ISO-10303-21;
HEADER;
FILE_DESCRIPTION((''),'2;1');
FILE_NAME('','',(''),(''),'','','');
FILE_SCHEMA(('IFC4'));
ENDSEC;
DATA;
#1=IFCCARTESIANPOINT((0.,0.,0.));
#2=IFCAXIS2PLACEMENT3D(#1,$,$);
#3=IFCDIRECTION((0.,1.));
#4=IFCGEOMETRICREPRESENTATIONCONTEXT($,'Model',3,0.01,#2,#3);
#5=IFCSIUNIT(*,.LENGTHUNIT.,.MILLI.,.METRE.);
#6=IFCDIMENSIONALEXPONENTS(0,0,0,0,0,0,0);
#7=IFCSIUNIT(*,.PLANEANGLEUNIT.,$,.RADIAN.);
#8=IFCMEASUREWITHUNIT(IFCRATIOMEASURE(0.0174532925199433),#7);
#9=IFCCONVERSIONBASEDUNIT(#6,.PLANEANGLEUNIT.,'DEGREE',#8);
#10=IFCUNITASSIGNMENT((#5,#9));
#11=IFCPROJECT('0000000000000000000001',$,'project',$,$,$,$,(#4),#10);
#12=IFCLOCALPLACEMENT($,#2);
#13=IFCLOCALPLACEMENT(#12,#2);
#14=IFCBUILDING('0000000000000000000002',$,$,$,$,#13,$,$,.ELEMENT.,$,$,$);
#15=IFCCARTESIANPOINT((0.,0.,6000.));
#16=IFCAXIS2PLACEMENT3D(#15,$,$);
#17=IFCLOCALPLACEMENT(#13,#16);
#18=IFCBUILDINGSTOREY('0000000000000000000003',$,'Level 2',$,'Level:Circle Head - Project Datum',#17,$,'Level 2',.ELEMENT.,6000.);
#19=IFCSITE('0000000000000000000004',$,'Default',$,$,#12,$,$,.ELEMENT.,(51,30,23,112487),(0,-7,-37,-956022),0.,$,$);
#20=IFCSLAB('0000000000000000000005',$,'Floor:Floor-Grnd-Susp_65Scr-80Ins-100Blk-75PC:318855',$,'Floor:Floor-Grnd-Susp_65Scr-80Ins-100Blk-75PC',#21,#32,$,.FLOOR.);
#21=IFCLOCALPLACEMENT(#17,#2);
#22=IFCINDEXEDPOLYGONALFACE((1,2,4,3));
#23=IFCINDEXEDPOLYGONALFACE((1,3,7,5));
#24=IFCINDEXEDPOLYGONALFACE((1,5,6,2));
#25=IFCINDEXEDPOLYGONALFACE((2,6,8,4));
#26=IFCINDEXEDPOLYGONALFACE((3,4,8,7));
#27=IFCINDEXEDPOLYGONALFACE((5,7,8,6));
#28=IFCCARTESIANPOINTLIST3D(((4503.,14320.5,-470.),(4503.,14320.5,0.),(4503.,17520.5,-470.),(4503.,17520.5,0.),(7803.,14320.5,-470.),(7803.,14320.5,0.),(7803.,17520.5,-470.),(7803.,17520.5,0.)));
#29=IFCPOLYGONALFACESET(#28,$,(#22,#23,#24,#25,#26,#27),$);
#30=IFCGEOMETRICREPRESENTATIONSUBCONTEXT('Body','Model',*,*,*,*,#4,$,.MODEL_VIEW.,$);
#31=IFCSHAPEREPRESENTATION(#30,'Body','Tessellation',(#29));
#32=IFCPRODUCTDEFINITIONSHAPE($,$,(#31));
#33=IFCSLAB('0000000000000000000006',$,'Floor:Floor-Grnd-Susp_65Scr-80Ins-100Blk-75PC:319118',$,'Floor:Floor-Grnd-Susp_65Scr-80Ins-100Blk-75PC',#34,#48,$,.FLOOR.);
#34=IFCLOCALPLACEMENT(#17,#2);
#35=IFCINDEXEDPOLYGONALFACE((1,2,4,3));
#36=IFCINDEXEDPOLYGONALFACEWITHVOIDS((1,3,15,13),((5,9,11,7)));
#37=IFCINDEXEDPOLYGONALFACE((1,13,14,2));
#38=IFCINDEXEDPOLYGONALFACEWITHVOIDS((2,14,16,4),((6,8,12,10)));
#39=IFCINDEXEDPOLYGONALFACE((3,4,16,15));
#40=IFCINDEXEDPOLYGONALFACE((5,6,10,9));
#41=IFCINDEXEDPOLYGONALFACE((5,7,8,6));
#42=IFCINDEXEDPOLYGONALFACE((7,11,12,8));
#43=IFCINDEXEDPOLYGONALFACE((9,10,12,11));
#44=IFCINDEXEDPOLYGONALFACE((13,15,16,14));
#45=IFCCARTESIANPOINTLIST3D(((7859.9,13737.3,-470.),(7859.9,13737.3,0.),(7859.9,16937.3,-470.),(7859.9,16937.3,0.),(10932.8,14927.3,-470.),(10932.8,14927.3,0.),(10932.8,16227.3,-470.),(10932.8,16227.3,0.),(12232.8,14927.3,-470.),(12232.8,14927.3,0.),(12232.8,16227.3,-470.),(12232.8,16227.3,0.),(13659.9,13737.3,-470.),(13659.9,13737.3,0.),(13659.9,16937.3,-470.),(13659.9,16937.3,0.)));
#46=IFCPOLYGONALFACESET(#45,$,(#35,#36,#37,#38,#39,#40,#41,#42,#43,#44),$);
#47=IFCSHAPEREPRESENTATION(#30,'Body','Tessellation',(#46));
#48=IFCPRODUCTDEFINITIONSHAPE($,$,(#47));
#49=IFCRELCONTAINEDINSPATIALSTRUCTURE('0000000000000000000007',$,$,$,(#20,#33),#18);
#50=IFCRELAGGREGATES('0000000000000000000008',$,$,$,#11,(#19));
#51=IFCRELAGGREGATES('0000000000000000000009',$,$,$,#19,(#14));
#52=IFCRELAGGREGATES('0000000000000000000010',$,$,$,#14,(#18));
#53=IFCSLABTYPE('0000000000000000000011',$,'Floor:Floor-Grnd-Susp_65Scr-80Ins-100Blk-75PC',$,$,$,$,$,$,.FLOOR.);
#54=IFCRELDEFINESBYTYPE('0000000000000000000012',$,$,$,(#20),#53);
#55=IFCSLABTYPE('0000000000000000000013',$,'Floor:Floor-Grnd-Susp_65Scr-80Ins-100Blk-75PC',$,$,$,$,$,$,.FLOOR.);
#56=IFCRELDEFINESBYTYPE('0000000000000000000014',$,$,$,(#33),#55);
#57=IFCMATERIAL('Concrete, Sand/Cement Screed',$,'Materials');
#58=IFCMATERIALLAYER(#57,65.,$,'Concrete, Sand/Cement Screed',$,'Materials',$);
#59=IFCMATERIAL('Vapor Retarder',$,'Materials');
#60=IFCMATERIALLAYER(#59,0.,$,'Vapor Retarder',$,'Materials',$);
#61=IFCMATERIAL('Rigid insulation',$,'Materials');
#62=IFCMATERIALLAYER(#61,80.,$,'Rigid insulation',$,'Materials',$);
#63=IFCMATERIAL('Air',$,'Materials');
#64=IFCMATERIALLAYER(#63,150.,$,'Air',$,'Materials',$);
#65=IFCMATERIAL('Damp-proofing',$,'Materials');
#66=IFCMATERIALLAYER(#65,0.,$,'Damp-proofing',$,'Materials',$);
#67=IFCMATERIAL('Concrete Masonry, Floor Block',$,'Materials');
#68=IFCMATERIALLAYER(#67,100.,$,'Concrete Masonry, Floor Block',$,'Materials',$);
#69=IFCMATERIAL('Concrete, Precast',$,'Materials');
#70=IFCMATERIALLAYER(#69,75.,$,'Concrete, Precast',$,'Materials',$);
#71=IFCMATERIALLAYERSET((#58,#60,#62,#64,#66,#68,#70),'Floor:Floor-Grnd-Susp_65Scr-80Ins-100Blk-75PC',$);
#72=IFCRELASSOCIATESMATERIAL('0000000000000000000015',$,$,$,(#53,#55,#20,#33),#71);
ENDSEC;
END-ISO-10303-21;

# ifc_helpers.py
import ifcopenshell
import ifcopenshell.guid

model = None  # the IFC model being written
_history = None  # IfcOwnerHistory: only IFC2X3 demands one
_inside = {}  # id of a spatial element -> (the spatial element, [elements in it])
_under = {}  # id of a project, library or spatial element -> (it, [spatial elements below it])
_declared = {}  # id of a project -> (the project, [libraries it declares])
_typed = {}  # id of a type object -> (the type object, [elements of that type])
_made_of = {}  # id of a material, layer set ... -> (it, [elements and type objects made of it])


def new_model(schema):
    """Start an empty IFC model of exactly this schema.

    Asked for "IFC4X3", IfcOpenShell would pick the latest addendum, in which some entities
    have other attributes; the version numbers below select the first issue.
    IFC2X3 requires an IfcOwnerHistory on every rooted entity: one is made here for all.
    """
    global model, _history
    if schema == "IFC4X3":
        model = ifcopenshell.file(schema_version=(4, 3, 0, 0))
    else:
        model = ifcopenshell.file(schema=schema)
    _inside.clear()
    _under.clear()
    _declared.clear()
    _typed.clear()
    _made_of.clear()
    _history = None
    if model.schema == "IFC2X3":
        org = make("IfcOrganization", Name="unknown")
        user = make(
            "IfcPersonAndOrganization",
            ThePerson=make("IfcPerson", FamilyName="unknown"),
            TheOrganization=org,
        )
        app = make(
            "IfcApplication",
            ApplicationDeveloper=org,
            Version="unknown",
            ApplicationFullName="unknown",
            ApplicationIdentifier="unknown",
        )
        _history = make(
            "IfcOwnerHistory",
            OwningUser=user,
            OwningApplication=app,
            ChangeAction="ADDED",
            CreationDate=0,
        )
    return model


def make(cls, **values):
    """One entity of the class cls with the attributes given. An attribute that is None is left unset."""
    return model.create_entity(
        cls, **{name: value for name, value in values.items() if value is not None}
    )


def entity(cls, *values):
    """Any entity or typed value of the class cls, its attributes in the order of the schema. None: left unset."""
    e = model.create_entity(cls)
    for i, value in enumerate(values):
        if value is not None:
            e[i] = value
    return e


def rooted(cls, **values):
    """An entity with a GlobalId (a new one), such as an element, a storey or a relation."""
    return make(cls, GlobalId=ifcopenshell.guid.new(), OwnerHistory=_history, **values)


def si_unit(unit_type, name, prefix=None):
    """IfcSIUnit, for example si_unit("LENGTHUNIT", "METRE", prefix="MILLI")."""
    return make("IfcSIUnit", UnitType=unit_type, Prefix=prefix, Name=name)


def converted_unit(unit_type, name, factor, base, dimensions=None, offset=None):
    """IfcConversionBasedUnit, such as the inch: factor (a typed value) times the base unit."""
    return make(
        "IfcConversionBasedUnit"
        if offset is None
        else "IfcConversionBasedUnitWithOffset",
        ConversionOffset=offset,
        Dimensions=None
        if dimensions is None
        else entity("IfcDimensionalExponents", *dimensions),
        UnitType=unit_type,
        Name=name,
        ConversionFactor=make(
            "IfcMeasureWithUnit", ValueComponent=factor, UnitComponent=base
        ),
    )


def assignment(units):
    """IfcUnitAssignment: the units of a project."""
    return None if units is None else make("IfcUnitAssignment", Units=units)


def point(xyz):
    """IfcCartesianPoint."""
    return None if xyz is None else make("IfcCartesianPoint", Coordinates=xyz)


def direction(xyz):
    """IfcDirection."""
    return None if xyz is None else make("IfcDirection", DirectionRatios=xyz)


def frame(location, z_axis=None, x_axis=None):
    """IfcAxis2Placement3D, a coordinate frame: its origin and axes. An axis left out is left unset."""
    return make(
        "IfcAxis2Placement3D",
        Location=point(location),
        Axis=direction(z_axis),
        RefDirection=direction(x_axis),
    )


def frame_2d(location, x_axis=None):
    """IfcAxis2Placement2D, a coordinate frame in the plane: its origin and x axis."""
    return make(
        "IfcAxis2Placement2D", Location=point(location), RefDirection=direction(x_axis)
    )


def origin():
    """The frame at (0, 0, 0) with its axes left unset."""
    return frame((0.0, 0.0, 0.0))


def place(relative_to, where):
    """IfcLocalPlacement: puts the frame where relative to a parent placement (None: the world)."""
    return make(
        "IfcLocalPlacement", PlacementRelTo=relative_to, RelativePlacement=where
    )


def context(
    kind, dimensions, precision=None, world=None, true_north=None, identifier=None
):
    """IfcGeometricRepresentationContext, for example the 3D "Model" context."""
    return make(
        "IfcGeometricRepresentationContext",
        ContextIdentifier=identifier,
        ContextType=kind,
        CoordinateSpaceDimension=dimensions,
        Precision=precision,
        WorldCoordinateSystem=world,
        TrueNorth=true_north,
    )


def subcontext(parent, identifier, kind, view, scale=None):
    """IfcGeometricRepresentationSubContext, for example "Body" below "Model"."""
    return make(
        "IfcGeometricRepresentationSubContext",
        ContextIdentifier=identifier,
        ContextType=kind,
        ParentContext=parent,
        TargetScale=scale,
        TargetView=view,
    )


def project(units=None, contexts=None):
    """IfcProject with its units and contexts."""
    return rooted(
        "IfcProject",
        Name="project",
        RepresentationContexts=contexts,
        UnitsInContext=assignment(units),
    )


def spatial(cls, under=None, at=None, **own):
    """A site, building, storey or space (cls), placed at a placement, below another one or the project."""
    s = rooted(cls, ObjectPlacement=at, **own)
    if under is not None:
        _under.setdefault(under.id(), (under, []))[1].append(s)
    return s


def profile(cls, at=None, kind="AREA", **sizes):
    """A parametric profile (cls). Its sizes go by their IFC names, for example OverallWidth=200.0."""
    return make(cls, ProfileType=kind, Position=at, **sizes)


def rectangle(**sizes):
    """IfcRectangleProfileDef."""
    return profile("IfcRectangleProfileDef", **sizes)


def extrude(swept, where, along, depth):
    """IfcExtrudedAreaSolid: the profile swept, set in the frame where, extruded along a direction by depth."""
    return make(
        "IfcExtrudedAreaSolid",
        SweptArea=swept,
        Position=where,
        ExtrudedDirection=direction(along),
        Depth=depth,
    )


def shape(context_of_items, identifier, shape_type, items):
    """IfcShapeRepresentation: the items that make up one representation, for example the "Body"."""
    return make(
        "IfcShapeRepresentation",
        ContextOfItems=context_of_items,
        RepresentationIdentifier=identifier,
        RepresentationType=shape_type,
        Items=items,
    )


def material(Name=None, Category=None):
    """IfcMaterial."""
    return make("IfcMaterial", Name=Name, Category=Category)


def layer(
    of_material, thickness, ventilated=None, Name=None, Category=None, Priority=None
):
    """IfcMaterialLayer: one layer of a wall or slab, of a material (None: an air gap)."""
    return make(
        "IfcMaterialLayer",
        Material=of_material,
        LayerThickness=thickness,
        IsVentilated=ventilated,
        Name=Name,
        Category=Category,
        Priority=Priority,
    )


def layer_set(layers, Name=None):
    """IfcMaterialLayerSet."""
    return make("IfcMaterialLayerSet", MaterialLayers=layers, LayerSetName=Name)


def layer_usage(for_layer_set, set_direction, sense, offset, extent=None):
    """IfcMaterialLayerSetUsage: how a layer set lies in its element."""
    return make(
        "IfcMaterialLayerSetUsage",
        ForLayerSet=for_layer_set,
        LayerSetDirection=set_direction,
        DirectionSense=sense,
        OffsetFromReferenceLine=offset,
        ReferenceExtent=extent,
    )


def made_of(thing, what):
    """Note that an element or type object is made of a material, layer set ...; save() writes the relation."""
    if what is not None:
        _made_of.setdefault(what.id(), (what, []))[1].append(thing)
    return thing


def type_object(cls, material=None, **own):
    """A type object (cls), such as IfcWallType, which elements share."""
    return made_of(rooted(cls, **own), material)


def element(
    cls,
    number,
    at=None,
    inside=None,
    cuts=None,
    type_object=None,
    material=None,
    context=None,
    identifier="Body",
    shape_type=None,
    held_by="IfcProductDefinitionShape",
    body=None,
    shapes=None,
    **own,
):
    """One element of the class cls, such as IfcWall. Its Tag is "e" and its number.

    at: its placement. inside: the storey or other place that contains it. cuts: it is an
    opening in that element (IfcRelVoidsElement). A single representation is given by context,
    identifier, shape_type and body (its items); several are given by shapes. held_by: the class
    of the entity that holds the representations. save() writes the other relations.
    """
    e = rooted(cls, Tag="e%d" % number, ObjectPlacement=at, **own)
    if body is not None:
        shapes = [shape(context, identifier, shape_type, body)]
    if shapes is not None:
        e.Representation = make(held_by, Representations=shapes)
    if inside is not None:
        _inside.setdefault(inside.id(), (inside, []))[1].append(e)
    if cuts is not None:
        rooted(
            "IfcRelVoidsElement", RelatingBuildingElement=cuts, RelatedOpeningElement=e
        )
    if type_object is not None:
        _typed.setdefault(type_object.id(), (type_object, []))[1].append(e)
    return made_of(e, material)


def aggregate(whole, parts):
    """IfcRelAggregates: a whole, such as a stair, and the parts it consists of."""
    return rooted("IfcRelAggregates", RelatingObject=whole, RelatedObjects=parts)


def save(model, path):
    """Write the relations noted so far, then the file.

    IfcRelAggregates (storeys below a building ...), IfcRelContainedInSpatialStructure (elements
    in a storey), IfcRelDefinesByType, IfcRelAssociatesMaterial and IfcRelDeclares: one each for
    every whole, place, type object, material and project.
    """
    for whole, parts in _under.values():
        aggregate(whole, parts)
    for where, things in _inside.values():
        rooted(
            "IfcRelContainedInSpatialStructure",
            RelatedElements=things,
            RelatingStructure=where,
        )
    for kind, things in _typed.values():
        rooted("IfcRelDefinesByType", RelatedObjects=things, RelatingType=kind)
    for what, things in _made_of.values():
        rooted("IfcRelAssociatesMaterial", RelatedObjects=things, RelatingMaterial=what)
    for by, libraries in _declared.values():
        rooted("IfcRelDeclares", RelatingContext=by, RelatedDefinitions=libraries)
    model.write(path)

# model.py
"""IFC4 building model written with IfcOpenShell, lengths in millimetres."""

from ifc_helpers import new_model, entity, si_unit, converted_unit, direction, frame, frame_2d, origin, place, context, subcontext, project, spatial, rectangle, extrude, material, layer, layer_set, layer_usage, type_object, element, save


model = new_model("IFC4")

# Units and contexts
model_context = context("Model", 3, precision=0.01, world=origin(), true_north=direction((0.0, 1.0)))
body_context = subcontext(model_context, "Body", "Model", "MODEL_VIEW")
ifc_project = project(units=[si_unit("LENGTHUNIT", "METRE", prefix="MILLI"), converted_unit("PLANEANGLEUNIT", "DEGREE", entity("IfcRatioMeasure", 0.0174532925199433), si_unit("PLANEANGLEUNIT", "RADIAN"), dimensions=[0, 0, 0, 0, 0, 0, 0])], contexts=[model_context])

# Site, building, storey
site_placement = place(None, origin())
site = spatial("IfcSite", under=ifc_project, at=site_placement, Name="Default", CompositionType="ELEMENT", RefLatitude=(51, 30, 23, 112487), RefLongitude=(0, -7, -37, -956022), RefElevation=0.0)
building_placement = place(site_placement, origin())
building = spatial("IfcBuilding", under=site, at=building_placement, CompositionType="ELEMENT")
storey_placement = place(building_placement, frame((0.0, 0.0, 6000.0)))
storey = spatial("IfcBuildingStorey", under=building, at=storey_placement, Name="Level 2", ObjectType="Level:Circle Head - Project Datum", LongName="Level 2", CompositionType="ELEMENT", Elevation=6000.0)

# Slab
ifc_material_1 = material(Name="Concrete, Sand/Cement Screed", Category="Materials")
ifc_layer_1 = layer(ifc_material_1, 65.0, Name="Concrete, Sand/Cement Screed", Category="Materials")
ifc_material_2 = material(Name="Vapor Retarder", Category="Materials")
ifc_layer_2 = layer(ifc_material_2, 0.0, Name="Vapor Retarder", Category="Materials")
ifc_material_3 = material(Name="Rigid insulation", Category="Materials")
ifc_layer_3 = layer(ifc_material_3, 80.0, Name="Rigid insulation", Category="Materials")
ifc_material_4 = material(Name="Air", Category="Materials")
ifc_layer_4 = layer(ifc_material_4, 150.0, Name="Air", Category="Materials")
ifc_material_5 = material(Name="Damp-proofing", Category="Materials")
ifc_layer_5 = layer(ifc_material_5, 0.0, Name="Damp-proofing", Category="Materials")
ifc_material_6 = material(Name="Concrete Masonry, Floor Block", Category="Materials")
ifc_layer_6 = layer(ifc_material_6, 100.0, Name="Concrete Masonry, Floor Block", Category="Materials")
ifc_material_7 = material(Name="Concrete, Precast", Category="Materials")
ifc_layer_7 = layer(ifc_material_7, 75.0, Name="Concrete, Precast", Category="Materials")
ifc_layer_set = layer_set([ifc_layer_1, ifc_layer_2, ifc_layer_3, ifc_layer_4, ifc_layer_5, ifc_layer_6, ifc_layer_7], Name="Floor:Floor-Grnd-Susp_65Scr-80Ins-100Blk-75PC")
ifc_layer_usage_1 = layer_usage(ifc_layer_set, "AXIS3", "POSITIVE", 0.0)
slab_type_1 = type_object("IfcSlabType", Name="Floor:Floor-Grnd-Susp_65Scr-80Ins-100Blk-75PC", PredefinedType="FLOOR", material=ifc_layer_set)
slab_1_placement = place(storey_placement, origin())
element("IfcSlab", 1, at=slab_1_placement, inside=storey, type_object=slab_type_1, material=ifc_layer_usage_1, Name="Floor:Floor-Grnd-Susp_65Scr-80Ins-100Blk-75PC:318855", ObjectType="Floor:Floor-Grnd-Susp_65Scr-80Ins-100Blk-75PC", PredefinedType="FLOOR", context=body_context, shape_type="SweptSolid", body=[
    extrude(rectangle(XDim=3200.0, YDim=3300.0, at=frame_2d((0.0, 0.0), x_axis=(1.0, 0.0))), frame((6153.0, 15920.5, 0.0), z_axis=(0.0, 0.0, -1.0), x_axis=(0.0, 1.0, 0.0)), (0.0, 0.0, 1.0), 470.0),
])

# Slab, opening
ifc_layer_usage_2 = layer_usage(ifc_layer_set, "AXIS3", "POSITIVE", 0.0)
slab_type_2 = type_object("IfcSlabType", Name="Floor:Floor-Grnd-Susp_65Scr-80Ins-100Blk-75PC", PredefinedType="FLOOR", material=ifc_layer_set)
slab_2_placement = place(storey_placement, frame((7859.9, 13737.3, -470.0)))
slab_2 = element("IfcSlab", 2, at=slab_2_placement, inside=storey, type_object=slab_type_2, material=ifc_layer_usage_2, Name="Floor:Floor-Grnd-Susp_65Scr-80Ins-100Blk-75PC:319118", ObjectType="Floor:Floor-Grnd-Susp_65Scr-80Ins-100Blk-75PC", PredefinedType="FLOOR", context=body_context, shape_type="SweptSolid", body=[
    extrude(rectangle(XDim=3200.0, YDim=5800.0, at=frame_2d((0.0, 0.0), x_axis=(0.0, -1.0))), frame((2900.0, 1600.0, 470.0), z_axis=(0.0, 0.0, -1.0), x_axis=(-1.0, 0.0, 0.0)), (0.0, 0.0, 1.0), 470.0),
])
opening_placement = place(storey_placement, frame((7859.9, 13737.3, -470.0)))
element("IfcOpeningElement", 3, at=opening_placement, cuts=slab_2, ObjectType="Opening", context=body_context, shape_type="SweptSolid", body=[
    extrude(rectangle(XDim=1300.0, YDim=1300.0, at=frame_2d((-822.9, 240.0), x_axis=(0.0, -1.0))), frame((2900.0, 1600.0, 470.0), z_axis=(0.0, 0.0, -1.0), x_axis=(-1.0, 0.0, 0.0)), (0.0, 0.0, 1.0), 470.0),
])

save(model, "model.ifc")
